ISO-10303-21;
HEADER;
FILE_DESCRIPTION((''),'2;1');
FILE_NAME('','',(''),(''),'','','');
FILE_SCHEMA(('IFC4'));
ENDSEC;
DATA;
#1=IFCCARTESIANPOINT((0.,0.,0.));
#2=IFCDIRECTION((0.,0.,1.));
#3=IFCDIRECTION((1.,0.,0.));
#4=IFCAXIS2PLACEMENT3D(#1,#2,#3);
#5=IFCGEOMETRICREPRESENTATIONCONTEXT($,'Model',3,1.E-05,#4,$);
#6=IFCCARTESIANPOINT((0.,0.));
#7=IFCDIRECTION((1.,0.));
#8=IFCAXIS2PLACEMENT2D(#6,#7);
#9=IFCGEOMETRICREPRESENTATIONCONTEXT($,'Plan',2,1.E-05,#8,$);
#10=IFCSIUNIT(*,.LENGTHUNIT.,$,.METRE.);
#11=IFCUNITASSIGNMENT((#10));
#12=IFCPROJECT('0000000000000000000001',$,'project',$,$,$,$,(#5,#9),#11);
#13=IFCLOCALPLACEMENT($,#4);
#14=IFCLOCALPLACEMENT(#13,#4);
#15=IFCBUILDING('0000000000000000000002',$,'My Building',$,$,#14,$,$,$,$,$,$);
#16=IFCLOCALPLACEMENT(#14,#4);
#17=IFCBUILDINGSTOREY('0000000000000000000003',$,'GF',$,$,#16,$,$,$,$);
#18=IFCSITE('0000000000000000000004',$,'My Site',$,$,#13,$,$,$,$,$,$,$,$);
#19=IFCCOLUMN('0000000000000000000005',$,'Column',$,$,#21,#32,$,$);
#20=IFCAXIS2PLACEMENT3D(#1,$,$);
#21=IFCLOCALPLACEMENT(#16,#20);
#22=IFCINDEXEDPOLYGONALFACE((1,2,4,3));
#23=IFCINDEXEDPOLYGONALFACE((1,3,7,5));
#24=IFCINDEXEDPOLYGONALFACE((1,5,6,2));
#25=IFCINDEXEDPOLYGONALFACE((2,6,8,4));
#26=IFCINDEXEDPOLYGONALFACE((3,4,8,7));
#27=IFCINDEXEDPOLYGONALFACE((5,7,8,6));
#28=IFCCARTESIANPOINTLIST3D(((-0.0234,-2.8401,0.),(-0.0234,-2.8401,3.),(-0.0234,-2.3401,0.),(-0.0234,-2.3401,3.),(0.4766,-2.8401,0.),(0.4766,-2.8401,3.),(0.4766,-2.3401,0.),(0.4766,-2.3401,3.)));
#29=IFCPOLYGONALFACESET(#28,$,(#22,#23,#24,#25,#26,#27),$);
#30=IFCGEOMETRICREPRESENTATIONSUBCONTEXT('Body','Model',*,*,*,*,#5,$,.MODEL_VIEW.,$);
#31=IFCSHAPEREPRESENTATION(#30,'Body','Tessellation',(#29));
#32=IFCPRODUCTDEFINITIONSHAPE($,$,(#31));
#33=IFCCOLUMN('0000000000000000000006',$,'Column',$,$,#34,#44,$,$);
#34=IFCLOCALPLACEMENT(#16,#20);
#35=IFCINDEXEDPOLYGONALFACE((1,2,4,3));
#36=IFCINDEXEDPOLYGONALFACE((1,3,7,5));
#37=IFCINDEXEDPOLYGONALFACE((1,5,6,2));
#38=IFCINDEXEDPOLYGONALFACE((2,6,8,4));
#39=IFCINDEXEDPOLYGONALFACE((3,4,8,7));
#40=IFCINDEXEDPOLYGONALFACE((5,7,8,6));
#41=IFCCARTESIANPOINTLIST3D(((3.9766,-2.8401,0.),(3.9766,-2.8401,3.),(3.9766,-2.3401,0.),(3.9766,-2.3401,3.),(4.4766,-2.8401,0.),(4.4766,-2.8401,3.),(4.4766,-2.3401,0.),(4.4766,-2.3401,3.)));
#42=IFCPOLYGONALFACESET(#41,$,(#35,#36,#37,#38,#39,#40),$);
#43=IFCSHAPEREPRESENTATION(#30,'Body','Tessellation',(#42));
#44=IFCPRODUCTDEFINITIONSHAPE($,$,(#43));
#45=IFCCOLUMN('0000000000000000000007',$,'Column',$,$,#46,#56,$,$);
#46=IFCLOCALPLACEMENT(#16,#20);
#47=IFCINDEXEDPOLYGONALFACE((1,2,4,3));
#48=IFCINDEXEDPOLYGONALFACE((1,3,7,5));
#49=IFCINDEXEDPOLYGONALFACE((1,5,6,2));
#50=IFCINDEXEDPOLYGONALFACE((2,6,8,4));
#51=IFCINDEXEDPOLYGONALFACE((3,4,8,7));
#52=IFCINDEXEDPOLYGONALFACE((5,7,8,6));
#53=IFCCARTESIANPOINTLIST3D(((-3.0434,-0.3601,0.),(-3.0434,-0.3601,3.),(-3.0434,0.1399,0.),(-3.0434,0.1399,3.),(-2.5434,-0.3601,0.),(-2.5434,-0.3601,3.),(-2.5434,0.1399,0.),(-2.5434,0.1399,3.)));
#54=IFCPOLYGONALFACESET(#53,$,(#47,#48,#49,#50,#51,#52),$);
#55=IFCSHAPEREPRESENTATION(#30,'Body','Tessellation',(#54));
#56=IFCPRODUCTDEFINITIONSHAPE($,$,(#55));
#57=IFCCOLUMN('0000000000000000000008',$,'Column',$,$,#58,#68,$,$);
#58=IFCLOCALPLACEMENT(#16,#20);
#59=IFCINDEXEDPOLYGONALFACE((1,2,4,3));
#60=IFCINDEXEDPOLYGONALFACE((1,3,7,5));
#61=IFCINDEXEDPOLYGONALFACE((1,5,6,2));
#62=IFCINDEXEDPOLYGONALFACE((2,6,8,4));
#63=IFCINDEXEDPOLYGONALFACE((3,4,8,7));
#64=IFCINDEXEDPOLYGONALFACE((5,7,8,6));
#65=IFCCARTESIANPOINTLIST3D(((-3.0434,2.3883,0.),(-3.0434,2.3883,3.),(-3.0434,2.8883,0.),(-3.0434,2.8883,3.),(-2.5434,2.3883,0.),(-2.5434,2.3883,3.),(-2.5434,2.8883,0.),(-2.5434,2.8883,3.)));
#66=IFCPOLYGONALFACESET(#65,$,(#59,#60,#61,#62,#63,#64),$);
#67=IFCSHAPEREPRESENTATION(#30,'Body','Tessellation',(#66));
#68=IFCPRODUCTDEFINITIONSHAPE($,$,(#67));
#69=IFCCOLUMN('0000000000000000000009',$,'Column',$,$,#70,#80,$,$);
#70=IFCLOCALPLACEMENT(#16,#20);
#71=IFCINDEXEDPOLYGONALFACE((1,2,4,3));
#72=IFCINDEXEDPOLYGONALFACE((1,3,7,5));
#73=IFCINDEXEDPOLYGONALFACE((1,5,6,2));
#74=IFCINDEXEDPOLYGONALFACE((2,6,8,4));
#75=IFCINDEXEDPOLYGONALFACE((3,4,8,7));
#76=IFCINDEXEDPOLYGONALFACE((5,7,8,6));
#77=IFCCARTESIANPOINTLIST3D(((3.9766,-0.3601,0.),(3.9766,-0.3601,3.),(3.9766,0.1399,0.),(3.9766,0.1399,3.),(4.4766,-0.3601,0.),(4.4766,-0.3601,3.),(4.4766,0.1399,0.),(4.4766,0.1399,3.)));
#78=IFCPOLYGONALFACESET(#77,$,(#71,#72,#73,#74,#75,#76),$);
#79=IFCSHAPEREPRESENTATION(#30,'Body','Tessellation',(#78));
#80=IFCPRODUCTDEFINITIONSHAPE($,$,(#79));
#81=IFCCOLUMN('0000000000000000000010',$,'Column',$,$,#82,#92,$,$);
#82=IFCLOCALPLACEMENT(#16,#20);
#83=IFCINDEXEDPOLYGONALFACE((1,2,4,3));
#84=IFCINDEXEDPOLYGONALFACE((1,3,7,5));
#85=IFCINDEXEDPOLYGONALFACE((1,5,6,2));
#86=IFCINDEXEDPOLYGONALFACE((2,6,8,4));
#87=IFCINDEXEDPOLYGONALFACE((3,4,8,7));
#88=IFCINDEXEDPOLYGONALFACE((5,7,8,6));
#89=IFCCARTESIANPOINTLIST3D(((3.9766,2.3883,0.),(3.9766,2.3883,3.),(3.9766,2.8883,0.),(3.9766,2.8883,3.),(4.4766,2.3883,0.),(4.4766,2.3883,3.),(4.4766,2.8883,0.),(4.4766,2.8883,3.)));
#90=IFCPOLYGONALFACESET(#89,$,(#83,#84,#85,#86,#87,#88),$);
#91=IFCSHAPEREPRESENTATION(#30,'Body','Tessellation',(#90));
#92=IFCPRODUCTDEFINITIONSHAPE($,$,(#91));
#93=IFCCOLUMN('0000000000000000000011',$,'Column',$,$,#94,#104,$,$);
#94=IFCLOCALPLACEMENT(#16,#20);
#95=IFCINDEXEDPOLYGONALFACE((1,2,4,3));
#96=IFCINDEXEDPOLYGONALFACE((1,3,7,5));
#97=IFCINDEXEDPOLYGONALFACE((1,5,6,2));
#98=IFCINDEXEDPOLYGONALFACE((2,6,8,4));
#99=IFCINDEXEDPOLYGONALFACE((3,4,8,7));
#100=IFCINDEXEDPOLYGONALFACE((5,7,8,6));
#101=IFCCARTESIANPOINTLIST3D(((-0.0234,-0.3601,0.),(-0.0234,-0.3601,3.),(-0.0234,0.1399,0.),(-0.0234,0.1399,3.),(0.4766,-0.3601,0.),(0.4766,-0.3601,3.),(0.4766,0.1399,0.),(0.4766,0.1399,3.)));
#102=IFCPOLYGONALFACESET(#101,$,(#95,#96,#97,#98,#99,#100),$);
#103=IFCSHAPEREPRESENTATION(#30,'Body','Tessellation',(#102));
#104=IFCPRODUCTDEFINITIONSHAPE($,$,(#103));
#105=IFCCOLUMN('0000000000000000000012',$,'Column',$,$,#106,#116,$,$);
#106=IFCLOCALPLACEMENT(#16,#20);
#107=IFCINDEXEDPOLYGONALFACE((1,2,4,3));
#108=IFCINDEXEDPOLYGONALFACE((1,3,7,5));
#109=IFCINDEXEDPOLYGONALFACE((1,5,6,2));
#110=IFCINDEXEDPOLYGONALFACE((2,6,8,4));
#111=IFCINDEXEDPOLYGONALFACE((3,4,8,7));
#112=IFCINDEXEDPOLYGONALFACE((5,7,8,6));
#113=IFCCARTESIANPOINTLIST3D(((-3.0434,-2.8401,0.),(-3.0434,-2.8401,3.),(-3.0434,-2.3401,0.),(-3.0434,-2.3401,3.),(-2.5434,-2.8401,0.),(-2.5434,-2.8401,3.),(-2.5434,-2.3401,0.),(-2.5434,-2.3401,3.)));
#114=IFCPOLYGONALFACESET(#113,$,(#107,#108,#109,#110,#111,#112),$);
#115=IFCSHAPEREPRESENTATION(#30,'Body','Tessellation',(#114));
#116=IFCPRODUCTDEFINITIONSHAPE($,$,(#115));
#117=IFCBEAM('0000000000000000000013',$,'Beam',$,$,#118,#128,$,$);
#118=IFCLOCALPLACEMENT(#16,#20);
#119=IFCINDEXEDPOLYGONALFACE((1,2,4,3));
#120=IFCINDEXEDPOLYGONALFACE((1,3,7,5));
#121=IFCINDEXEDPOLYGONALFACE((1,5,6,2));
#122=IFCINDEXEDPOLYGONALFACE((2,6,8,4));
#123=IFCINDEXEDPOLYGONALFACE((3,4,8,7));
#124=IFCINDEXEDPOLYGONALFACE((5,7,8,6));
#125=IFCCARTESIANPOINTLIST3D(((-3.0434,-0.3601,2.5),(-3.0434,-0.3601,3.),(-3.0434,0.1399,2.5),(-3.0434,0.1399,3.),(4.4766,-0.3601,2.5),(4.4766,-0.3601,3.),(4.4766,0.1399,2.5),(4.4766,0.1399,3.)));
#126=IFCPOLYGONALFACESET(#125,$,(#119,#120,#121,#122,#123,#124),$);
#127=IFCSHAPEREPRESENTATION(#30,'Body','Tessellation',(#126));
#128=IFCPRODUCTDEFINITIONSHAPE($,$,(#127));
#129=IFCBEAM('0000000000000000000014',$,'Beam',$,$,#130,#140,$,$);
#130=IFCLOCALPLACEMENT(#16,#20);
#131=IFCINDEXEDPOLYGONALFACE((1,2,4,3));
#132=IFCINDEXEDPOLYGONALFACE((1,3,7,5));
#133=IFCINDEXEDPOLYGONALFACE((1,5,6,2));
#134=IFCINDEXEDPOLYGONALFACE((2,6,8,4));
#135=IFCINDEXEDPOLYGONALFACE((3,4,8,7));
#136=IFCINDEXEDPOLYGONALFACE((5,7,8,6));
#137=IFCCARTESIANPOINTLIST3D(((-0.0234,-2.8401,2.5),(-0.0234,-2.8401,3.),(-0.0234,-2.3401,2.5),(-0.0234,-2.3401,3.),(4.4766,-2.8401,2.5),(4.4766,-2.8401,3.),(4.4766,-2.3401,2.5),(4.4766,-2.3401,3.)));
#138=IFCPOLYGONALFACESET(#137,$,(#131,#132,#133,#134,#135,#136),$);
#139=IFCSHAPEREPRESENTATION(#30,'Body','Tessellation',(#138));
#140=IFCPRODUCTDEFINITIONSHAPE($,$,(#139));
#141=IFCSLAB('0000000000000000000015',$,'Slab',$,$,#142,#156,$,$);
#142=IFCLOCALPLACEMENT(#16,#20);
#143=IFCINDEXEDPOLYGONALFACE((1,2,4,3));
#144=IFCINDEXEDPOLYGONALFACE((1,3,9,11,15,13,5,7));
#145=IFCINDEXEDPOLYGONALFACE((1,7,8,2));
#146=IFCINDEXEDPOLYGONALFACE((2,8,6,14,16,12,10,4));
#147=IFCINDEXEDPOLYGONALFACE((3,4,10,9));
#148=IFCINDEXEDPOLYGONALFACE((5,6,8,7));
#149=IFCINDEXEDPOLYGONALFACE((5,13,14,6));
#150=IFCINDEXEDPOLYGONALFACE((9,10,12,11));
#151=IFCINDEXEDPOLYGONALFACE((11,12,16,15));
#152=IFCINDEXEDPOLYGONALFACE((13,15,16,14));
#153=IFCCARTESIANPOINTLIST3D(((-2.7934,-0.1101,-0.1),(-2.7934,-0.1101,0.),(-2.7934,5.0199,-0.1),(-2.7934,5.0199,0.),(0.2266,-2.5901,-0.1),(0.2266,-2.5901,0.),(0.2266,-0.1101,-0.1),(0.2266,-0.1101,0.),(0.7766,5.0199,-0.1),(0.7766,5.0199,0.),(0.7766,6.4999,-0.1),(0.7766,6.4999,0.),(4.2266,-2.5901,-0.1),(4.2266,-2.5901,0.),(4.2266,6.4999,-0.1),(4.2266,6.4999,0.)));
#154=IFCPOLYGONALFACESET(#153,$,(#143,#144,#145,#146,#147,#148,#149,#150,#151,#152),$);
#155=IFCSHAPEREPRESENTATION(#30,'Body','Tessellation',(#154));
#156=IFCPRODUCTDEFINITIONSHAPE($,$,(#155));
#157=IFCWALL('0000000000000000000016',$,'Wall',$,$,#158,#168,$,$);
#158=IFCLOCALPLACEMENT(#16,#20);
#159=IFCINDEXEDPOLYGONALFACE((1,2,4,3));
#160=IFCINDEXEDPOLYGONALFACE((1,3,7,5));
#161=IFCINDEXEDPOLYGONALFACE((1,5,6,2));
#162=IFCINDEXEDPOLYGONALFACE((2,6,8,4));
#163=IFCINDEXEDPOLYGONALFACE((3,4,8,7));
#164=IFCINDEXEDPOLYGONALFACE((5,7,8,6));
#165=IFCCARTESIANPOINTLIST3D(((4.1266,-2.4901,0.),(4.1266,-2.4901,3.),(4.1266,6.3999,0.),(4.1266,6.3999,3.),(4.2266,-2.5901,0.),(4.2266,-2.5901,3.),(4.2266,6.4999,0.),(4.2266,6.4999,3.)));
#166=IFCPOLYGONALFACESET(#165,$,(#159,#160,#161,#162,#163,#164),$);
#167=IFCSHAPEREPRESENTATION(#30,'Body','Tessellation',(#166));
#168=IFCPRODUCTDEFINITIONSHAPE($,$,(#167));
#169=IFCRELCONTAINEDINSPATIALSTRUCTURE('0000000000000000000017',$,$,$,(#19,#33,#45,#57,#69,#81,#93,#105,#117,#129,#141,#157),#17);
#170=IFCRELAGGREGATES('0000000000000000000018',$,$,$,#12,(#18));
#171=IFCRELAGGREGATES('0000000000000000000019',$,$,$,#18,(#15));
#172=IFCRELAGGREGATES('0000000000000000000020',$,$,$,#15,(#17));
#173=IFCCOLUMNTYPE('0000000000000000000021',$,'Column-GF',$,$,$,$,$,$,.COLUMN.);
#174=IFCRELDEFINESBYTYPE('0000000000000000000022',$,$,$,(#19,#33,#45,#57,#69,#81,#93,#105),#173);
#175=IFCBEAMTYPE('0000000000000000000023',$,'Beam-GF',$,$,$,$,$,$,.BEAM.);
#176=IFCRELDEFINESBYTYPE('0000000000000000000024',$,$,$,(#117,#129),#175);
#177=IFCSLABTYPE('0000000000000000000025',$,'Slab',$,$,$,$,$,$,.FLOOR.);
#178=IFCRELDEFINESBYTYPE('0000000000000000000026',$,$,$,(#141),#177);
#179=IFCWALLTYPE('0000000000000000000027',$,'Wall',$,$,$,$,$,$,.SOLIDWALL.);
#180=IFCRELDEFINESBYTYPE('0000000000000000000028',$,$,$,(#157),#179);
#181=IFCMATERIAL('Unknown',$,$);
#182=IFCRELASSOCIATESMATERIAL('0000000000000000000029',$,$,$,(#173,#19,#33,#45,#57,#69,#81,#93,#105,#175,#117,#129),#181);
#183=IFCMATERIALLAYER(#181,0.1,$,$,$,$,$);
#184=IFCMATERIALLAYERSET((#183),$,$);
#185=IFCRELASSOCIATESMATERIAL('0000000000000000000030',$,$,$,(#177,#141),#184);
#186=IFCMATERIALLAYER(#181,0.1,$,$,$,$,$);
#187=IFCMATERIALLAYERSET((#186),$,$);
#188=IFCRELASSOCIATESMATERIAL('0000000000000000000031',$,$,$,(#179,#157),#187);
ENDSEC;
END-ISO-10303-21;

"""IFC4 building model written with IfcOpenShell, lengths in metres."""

from ifc_helpers import new_model, si_unit, frame, origin_with_axes, origin_2d_with_axis, place, context, subcontext, project, spatial, line, indexed_curve, rectangle, outline, extrude, material, layer, layer_set, layer_usage, material_profile, profile_set, profile_usage, type_object, element, save


model = new_model("IFC4")

# Units and contexts
model_context = context("Model", 3, precision=1e-05, world=origin_with_axes())
plan_context = context("Plan", 2, precision=1e-05, world=origin_2d_with_axis())
body_context_1 = subcontext(model_context, "Body", "Model", "MODEL_VIEW")
ifc_project = project(units=[si_unit("LENGTHUNIT", "METRE")], contexts=[model_context, plan_context])

# Site, building, storey
site_placement = place(None, origin_with_axes())
site = spatial("IfcSite", under=ifc_project, at=site_placement, Name="My Site")
building_placement = place(site_placement, origin_with_axes())
building = spatial("IfcBuilding", under=site, at=building_placement, Name="My Building")
storey_placement = place(building_placement, origin_with_axes())
storey = spatial("IfcBuildingStorey", under=building, at=storey_placement, Name="GF")

# Columns
ifc_material = material(Name="Unknown")
ifc_material_profile_1 = material_profile(ifc_material, rectangle(XDim=0.5, YDim=0.5))
ifc_profile_set_1 = profile_set([ifc_material_profile_1])
ifc_profile_usage_1 = profile_usage(ifc_profile_set_1, cardinal=5)
column_type = type_object("IfcColumnType", Name="Column-GF", PredefinedType="COLUMN", material=ifc_profile_set_1)
column_1_placement = place(storey_placement, frame((0.2266, -2.5901, 0.0), z_axis=(0.0, 0.0, 1.0), x_axis=(1.0, 0.0, 0.0)))
element("IfcColumn", 1, at=column_1_placement, inside=storey, type_object=column_type, material=ifc_profile_usage_1, Name="Column", context=body_context_1, shape_type="SweptSolid", body=[
    extrude(rectangle(XDim=0.5, YDim=0.5), origin_with_axes(), (0.0, 0.0, 1.0), 3.0),
])
ifc_profile_usage_2 = profile_usage(ifc_profile_set_1, cardinal=5)
column_2_placement = place(storey_placement, frame((4.2266, -2.5901, 0.0), z_axis=(0.0, 0.0, 1.0), x_axis=(1.0, 0.0, 0.0)))
element("IfcColumn", 2, at=column_2_placement, inside=storey, type_object=column_type, material=ifc_profile_usage_2, Name="Column", context=body_context_1, shape_type="SweptSolid", body=[
    extrude(rectangle(XDim=0.5, YDim=0.5), origin_with_axes(), (0.0, 0.0, 1.0), 3.0),
])
ifc_profile_usage_3 = profile_usage(ifc_profile_set_1, cardinal=5)
column_3_placement = place(storey_placement, frame((-2.7934, -0.1101, 0.0), z_axis=(0.0, 0.0, 1.0), x_axis=(1.0, 0.0, 0.0)))
element("IfcColumn", 3, at=column_3_placement, inside=storey, type_object=column_type, material=ifc_profile_usage_3, Name="Column", context=body_context_1, shape_type="SweptSolid", body=[
    extrude(rectangle(XDim=0.5, YDim=0.5), origin_with_axes(), (0.0, 0.0, 1.0), 3.0),
])
ifc_profile_usage_4 = profile_usage(ifc_profile_set_1, cardinal=5)
column_4_placement = place(storey_placement, frame((-2.7934, 2.6383, 0.0), z_axis=(0.0, 0.0, 1.0), x_axis=(1.0, 0.0, 0.0)))
element("IfcColumn", 4, at=column_4_placement, inside=storey, type_object=column_type, material=ifc_profile_usage_4, Name="Column", context=body_context_1, shape_type="SweptSolid", body=[
    extrude(rectangle(XDim=0.5, YDim=0.5), origin_with_axes(), (0.0, 0.0, 1.0), 3.0),
])
ifc_profile_usage_5 = profile_usage(ifc_profile_set_1, cardinal=5)
column_5_placement = place(storey_placement, frame((4.2266, -0.1101, 0.0), z_axis=(0.0, 0.0, 1.0), x_axis=(1.0, 0.0, 0.0)))
element("IfcColumn", 5, at=column_5_placement, inside=storey, type_object=column_type, material=ifc_profile_usage_5, Name="Column", context=body_context_1, shape_type="SweptSolid", body=[
    extrude(rectangle(XDim=0.5, YDim=0.5), origin_with_axes(), (0.0, 0.0, 1.0), 3.0),
])
ifc_profile_usage_6 = profile_usage(ifc_profile_set_1, cardinal=5)
column_6_placement = place(storey_placement, frame((4.2266, 2.6383, 0.0), z_axis=(0.0, 0.0, 1.0), x_axis=(1.0, 0.0, 0.0)))
element("IfcColumn", 6, at=column_6_placement, inside=storey, type_object=column_type, material=ifc_profile_usage_6, Name="Column", context=body_context_1, shape_type="SweptSolid", body=[
    extrude(rectangle(XDim=0.5, YDim=0.5), origin_with_axes(), (0.0, 0.0, 1.0), 3.0),
])
ifc_profile_usage_7 = profile_usage(ifc_profile_set_1, cardinal=5)
column_7_placement = place(storey_placement, frame((0.2266, -0.1101, 0.0), z_axis=(0.0, 0.0, 1.0), x_axis=(1.0, 0.0, 0.0)))
element("IfcColumn", 7, at=column_7_placement, inside=storey, type_object=column_type, material=ifc_profile_usage_7, Name="Column", context=body_context_1, shape_type="SweptSolid", body=[
    extrude(rectangle(XDim=0.5, YDim=0.5), origin_with_axes(), (0.0, 0.0, 1.0), 3.0),
])
ifc_profile_usage_8 = profile_usage(ifc_profile_set_1, cardinal=5)
column_8_placement = place(storey_placement, frame((-2.7934, -2.5901, 0.0), z_axis=(0.0, 0.0, 1.0), x_axis=(1.0, 0.0, 0.0)))
element("IfcColumn", 8, at=column_8_placement, inside=storey, type_object=column_type, material=ifc_profile_usage_8, Name="Column", context=body_context_1, shape_type="SweptSolid", body=[
    extrude(rectangle(XDim=0.5, YDim=0.5), origin_with_axes(), (0.0, 0.0, 1.0), 3.0),
])

# Beams
ifc_material_profile_2 = material_profile(ifc_material, rectangle(XDim=0.5, YDim=0.5))
ifc_profile_set_2 = profile_set([ifc_material_profile_2])
ifc_profile_usage_9 = profile_usage(ifc_profile_set_2, cardinal=7)
beam_type = type_object("IfcBeamType", Name="Beam-GF", PredefinedType="BEAM", material=ifc_profile_set_2)
beam_1_placement = place(storey_placement, frame((-3.0434, 0.1399, 3.0), z_axis=(1.0, 0.0, 0.0), x_axis=(0.0, 1.0, 0.0)))
element("IfcBeam", 9, at=beam_1_placement, inside=storey, type_object=beam_type, material=ifc_profile_usage_9, Name="Beam", context=body_context_1, shape_type="SweptSolid", body=[
    extrude(rectangle(XDim=0.5, YDim=0.5), frame((-0.25, -0.25, 0.0), z_axis=(0.0, 0.0, 1.0), x_axis=(1.0, 0.0, 0.0)), (0.0, 0.0, 1.0), 7.52),
])
ifc_profile_usage_10 = profile_usage(ifc_profile_set_2, cardinal=7)
beam_2_placement = place(storey_placement, frame((-0.0234, -2.3401, 3.0), z_axis=(1.0, -0.000001, 0.000001), x_axis=(0.000001, 1.0, 0.0)))
element("IfcBeam", 10, at=beam_2_placement, inside=storey, type_object=beam_type, material=ifc_profile_usage_10, Name="Beam", context=body_context_1, shape_type="SweptSolid", body=[
    extrude(rectangle(XDim=0.5, YDim=0.5), frame((-0.25, -0.25, 0.0), z_axis=(0.0, 0.0, 1.0), x_axis=(1.0, 0.0, 0.0)), (0.0, 0.0, 1.0), 4.5),
])

# Slab
ifc_layer_1 = layer(ifc_material, 0.1)
ifc_layer_set_1 = layer_set([ifc_layer_1])
ifc_layer_usage_1 = layer_usage(ifc_layer_set_1, "AXIS3", "POSITIVE", -0.1)
slab_type_1 = type_object("IfcSlabType", Name="Slab", PredefinedType="FLOOR", material=ifc_layer_set_1)
slab_1_placement = place(storey_placement, frame((4.2266, -2.5901, 0.0), z_axis=(0.0, 0.0, 1.0), x_axis=(1.0, 0.0, 0.0)))
element("IfcSlab", 11, at=slab_1_placement, inside=storey, type_object=slab_type_1, material=ifc_layer_usage_1, Name="Slab", context=body_context_1, shape_type="SweptSolid", body=[
    extrude(outline(indexed_curve([(0.0, 0.0), (0.0, 9.09), (-3.45, 9.09), (-3.45, 7.61), (-7.02, 7.61), (-7.02, 2.48), (-4.0, 2.48), (-4.0, 0.0), (0.0, 0.0)])), frame((0.0, 0.0, -0.1), z_axis=(0.0, 0.0, 1.0), x_axis=(1.0, 0.0, 0.0)), (0.0, 0.0, 1.0), 0.1),
])

# Shared definitions
ifc_layer_2 = layer(ifc_material, 0.1)
ifc_layer_set_2 = layer_set([ifc_layer_2])
wall_type = type_object("IfcWallType", Name="Wall", PredefinedType="SOLIDWALL", material=ifc_layer_set_2)

# Wall
ifc_layer_usage_2 = layer_usage(ifc_layer_set_2, "AXIS2", "POSITIVE", 0.0)
wall_1_placement = place(storey_placement, frame((4.2266, -2.5901, 0.0), z_axis=(0.0, 0.0, 1.0), x_axis=(0.0, 1.0, 0.0)))
element("IfcWall", 12, at=wall_1_placement, inside=storey, type_object=wall_type, material=ifc_layer_usage_2, Name="Wall", context=body_context_1, shape_type="SweptSolid", body=[
    extrude(outline(indexed_curve([(0.0, 0.0), (0.1, 0.1), (8.99, 0.1), (9.09, 0.0)], segments=[line(1, 2, 3, 4, 1)])), origin_with_axes(), (0.0, 0.0, 1.0), 3.0),
])

save(model, "model.ifc")
